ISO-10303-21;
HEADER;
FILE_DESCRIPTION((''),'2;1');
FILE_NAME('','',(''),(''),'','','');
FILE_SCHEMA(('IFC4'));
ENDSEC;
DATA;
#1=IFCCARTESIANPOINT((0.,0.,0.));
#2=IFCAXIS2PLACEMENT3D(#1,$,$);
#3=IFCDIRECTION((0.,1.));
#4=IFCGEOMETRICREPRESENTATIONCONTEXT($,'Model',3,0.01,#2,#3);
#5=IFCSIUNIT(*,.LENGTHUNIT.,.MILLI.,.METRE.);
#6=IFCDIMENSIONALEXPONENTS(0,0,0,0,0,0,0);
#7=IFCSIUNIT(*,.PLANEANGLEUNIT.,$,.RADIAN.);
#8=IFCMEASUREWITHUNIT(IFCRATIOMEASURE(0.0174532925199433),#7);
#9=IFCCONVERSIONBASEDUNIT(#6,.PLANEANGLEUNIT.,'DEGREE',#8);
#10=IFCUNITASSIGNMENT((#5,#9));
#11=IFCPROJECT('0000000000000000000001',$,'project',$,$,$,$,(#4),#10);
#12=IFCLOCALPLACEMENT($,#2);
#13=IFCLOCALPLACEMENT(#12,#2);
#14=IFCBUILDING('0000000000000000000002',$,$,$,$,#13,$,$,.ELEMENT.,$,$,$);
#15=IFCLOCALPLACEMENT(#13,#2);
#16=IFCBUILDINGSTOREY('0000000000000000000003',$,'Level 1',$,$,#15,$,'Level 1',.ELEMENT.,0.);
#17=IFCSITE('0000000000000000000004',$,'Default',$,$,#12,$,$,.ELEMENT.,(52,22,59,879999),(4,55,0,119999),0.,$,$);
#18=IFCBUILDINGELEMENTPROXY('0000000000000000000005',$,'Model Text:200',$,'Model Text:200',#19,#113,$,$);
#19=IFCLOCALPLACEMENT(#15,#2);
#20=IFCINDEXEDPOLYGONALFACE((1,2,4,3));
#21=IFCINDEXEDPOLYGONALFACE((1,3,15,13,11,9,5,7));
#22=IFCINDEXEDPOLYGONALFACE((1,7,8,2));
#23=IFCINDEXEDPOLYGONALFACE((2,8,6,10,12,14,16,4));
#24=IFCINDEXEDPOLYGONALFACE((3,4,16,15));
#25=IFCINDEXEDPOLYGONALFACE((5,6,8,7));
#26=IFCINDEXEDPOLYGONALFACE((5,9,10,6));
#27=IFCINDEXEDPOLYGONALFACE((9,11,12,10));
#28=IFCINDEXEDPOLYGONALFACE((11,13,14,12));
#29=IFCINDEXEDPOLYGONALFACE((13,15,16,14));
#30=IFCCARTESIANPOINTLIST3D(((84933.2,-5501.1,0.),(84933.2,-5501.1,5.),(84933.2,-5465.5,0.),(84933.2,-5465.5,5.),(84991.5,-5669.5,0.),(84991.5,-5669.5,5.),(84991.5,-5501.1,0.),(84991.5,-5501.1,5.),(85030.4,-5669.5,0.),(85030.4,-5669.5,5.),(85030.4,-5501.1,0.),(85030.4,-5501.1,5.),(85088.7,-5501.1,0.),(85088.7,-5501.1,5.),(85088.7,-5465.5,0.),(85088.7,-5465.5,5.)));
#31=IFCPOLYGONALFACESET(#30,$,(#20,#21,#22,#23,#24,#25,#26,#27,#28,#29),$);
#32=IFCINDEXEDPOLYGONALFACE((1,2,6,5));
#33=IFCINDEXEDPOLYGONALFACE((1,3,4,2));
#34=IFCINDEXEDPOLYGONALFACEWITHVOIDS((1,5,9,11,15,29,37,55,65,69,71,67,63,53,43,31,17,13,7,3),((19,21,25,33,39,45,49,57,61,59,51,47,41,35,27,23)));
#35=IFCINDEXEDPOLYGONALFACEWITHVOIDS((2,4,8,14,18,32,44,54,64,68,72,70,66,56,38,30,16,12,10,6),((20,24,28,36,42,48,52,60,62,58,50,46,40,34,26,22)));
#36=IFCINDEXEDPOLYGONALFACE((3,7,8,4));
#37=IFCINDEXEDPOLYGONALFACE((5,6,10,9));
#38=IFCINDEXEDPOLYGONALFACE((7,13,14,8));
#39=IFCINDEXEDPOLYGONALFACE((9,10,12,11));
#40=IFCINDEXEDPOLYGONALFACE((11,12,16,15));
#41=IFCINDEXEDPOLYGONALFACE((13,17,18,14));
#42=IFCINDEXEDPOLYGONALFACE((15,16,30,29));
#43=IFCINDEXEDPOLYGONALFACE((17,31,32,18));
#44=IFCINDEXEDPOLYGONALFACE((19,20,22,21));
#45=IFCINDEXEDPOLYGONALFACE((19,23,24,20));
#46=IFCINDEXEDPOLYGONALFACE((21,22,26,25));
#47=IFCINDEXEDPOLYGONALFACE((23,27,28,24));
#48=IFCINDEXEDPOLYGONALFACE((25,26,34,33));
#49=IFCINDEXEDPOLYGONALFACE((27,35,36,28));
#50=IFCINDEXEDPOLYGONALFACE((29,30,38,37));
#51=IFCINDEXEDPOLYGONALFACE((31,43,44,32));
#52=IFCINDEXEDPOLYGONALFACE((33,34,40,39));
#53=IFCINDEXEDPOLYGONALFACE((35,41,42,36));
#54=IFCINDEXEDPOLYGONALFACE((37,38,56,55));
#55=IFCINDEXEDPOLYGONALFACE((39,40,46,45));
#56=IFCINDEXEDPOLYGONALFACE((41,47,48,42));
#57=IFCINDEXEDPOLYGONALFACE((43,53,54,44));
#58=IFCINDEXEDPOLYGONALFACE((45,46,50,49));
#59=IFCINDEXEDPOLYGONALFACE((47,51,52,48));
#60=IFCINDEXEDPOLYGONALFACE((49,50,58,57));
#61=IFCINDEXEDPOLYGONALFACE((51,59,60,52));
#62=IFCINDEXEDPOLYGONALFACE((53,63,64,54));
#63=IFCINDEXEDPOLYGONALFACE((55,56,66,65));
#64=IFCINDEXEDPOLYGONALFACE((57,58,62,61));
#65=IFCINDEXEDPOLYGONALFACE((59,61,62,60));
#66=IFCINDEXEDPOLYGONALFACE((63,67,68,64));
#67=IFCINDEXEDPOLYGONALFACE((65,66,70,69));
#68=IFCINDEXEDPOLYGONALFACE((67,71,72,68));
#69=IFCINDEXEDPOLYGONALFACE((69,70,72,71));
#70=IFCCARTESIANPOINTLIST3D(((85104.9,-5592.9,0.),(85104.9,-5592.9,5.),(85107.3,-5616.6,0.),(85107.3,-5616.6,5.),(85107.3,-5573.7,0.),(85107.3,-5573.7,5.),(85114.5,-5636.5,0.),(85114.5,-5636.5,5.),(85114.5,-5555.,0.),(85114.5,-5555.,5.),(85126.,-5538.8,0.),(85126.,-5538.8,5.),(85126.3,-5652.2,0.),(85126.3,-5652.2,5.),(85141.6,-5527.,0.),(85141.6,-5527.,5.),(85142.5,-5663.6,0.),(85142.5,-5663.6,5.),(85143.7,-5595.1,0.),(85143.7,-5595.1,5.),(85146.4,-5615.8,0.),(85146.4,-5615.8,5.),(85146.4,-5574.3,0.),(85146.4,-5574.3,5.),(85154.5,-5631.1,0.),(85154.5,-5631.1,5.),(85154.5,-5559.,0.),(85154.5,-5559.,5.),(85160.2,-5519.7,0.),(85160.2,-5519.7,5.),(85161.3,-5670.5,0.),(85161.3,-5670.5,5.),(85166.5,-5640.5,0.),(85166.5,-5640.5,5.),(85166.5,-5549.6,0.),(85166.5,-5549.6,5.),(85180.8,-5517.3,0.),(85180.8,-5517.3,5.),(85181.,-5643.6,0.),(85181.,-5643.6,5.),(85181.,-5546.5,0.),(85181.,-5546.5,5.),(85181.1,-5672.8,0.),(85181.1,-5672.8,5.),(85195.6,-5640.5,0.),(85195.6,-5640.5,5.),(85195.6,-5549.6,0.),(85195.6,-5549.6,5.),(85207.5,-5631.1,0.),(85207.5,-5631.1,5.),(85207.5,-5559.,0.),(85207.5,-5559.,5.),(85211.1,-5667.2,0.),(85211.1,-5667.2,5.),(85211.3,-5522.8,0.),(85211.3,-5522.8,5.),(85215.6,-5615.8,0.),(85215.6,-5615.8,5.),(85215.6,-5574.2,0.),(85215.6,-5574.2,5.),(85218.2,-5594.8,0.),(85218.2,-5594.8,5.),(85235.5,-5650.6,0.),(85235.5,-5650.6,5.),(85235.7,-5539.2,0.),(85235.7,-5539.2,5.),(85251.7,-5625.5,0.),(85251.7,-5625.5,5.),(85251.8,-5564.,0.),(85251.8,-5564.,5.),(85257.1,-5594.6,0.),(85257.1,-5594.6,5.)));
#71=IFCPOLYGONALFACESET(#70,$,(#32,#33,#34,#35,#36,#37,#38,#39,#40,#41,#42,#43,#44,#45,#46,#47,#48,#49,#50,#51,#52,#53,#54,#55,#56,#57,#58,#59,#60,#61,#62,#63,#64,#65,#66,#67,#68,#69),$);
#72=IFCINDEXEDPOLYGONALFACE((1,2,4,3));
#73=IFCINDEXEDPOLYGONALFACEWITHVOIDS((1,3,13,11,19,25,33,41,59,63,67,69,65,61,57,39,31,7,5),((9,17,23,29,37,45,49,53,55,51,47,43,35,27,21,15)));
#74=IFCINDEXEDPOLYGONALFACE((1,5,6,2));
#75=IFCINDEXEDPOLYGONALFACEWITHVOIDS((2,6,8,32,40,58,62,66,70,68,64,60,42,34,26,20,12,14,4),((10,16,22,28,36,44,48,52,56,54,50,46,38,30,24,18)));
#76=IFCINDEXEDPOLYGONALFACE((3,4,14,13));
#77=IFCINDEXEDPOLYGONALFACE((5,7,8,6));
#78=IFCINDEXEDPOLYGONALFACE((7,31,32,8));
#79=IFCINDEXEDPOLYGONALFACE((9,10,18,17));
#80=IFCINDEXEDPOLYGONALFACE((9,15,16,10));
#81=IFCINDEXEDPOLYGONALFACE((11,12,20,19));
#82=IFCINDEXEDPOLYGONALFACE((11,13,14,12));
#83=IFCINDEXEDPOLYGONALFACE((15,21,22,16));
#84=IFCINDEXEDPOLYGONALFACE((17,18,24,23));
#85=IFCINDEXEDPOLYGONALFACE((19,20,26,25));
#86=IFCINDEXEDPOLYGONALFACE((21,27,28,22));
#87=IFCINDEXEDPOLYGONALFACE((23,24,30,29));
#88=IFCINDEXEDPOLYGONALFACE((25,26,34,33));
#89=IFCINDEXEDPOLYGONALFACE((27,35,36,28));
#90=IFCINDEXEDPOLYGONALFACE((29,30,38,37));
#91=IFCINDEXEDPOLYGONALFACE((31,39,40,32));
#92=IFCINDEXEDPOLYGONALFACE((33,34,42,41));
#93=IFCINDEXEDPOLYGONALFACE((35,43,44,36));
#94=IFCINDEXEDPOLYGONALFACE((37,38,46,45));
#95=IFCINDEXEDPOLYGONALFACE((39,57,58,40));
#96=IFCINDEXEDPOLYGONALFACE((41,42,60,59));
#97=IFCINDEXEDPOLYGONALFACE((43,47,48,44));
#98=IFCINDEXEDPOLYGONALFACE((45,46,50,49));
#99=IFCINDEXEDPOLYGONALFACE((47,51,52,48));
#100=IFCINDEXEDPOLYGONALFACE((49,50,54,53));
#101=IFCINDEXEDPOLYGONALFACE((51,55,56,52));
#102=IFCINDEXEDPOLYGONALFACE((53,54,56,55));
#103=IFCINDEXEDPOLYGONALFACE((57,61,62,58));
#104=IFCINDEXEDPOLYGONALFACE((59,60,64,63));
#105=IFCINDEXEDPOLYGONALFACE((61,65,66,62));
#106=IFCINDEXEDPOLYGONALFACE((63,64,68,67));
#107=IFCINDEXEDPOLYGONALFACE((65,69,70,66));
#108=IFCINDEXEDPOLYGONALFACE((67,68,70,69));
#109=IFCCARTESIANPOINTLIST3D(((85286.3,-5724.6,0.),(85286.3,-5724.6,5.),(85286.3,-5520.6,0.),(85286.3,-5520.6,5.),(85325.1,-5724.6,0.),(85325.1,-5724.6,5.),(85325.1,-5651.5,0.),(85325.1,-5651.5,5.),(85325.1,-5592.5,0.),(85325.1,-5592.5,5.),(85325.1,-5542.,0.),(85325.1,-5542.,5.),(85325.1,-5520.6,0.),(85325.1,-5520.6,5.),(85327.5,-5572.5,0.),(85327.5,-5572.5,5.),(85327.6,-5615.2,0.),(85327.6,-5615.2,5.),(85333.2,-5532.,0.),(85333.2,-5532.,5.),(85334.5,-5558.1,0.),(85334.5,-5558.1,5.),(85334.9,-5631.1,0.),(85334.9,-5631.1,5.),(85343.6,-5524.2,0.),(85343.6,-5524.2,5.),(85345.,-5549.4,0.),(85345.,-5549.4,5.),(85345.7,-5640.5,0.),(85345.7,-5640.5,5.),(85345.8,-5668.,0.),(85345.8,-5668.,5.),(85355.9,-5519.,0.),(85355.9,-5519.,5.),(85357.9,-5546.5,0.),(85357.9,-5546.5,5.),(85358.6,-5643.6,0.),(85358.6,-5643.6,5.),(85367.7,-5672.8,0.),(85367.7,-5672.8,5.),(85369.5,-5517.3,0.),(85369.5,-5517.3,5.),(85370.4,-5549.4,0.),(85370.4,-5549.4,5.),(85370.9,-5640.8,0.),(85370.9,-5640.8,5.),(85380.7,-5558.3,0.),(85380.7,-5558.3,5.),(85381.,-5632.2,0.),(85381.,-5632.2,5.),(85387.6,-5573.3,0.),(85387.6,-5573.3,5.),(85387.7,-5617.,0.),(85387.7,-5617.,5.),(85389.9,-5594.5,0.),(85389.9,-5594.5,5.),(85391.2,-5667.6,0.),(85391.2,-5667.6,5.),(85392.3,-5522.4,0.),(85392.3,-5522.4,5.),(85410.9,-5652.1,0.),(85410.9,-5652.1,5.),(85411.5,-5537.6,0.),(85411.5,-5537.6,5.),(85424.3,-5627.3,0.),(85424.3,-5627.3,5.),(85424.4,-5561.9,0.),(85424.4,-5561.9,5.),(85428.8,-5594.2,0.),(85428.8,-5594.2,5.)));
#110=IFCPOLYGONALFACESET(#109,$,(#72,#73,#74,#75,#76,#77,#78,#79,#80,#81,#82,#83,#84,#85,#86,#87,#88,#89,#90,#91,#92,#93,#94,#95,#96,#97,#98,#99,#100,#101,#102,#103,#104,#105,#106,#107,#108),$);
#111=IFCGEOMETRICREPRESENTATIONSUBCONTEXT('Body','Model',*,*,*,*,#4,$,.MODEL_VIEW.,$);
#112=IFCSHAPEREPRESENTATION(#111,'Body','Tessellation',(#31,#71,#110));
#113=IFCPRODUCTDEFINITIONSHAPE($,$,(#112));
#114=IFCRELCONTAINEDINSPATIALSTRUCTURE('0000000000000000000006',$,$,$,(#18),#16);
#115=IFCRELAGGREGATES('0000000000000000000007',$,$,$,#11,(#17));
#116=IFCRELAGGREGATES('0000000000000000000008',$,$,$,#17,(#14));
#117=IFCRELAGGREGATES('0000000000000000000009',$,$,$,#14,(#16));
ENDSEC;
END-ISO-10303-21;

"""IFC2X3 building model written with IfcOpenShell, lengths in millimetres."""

from ifc_helpers import new_model, entity, si_unit, converted_unit, direction, frame, origin, place, context, subcontext, project, spatial, polyline, outline, extrude, element, save


model = new_model("IFC2X3")

# Units and contexts
model_context = context("Model", 3, precision=0.01, world=origin(), true_north=direction((0.0, 1.0)))
body_context = subcontext(model_context, "Body", "Model", "MODEL_VIEW")
ifc_project = project(units=[si_unit("LENGTHUNIT", "METRE", prefix="MILLI"), converted_unit("PLANEANGLEUNIT", "DEGREE", entity("IfcRatioMeasure", 0.0174532925199433), si_unit("PLANEANGLEUNIT", "RADIAN"), dimensions=[0, 0, 0, 0, 0, 0, 0])], contexts=[model_context])

# Site, building, storey
site_placement = place(None, origin())
site = spatial("IfcSite", under=ifc_project, at=site_placement, Name="Default", CompositionType="ELEMENT", RefLatitude=(52, 22, 59, 879999), RefLongitude=(4, 55, 0, 119999), RefElevation=0.0)
building_placement = place(site_placement, origin())
building = spatial("IfcBuilding", under=site, at=building_placement, CompositionType="ELEMENT")
storey_placement = place(building_placement, origin())
storey = spatial("IfcBuildingStorey", under=building, at=storey_placement, Name="Level 1", LongName="Level 1", CompositionType="ELEMENT", Elevation=0.0)

# Building element proxy
proxy_1_placement = place(building_placement, origin())
element("IfcBuildingElementProxy", 1, at=proxy_1_placement, inside=storey, Name="Model Text:200", ObjectType="Model Text:200", context=body_context, shape_type="SweptSolid", body=[
    extrude(outline(polyline([(-19.4, -135.2), (19.4, -135.2), (19.4, 33.2), (77.7, 33.2), (77.7, 68.8), (-77.7, 68.8), (-77.7, 33.2), (-19.4, 33.2), (-19.4, -135.2)])), frame((85010.9, -5534.3, 0.0)), (0.0, 0.0, 1.0), 5.0),
    extrude(outline(polyline([(-8.8, -65.7), (15.1, -65.7), (35.5, -60.5), (52.3, -50.4), (65.3, -35.4), (74.1, -17.3), (78.4, 2.1), (75.9, 32.5), (61.8, 58.5), (38.4, 77.1), (8.3, 85.6), (-22.7, 83.3), (-49.0, 69.9), (-67.8, 47.3), (-76.3, 17.5), (-76.0, -3.3), (-70.7, -22.5), (-60.5, -39.2), (-45.5, -52.3), (-27.7, -61.4), (-8.8, -65.7)]), holes=[polyline([(-2.7, -27.2), (-23.1, -22.5), (-37.5, -12.9), (-45.7, 0.0), (-47.3, 14.8), (-42.7, 28.9), (-32.2, 39.9), (-16.3, 46.3), (4.5, 46.9), (25.1, 42.1), (39.6, 32.6), (47.7, 19.7), (49.4, 5.0), (44.8, -9.2), (34.2, -20.2), (18.2, -26.7), (-2.7, -27.2)])]), frame((85171.1, -5595.0, 0.0), z_axis=(0.0, 0.0, 1.0), x_axis=(0.100608, -0.994926, 0.0)), (0.0, 0.0, 1.0), 5.0),
    extrude(outline(polyline([(-73.1, -75.4), (130.9, -75.4), (130.9, -36.6), (57.8, -36.6), (74.3, -15.9), (79.1, 6.0), (73.9, 29.5), (58.4, 49.2), (33.6, 62.6), (0.5, 67.1), (-31.8, 62.8), (-56.1, 49.8), (-71.3, 30.7), (-76.4, 7.8), (-74.7, -5.8), (-69.6, -18.1), (-61.7, -28.5), (-51.7, -36.6), (-73.1, -36.6), (-73.1, -75.4)]), holes=[polyline([(-1.2, -36.6), (-21.2, -34.2), (-35.6, -27.2), (-44.3, -16.7), (-47.2, -3.8), (-44.3, 8.7), (-35.4, 19.0), (-20.4, 25.9), (0.8, 28.2), (23.3, 26.0), (38.5, 19.3), (47.1, 9.2), (49.9, -3.1), (46.8, -16.0), (37.4, -26.8), (21.5, -34.1), (-1.2, -36.6)])]), frame((85361.7, -5593.7, 0.0), z_axis=(0.0, 0.0, 1.0), x_axis=(0.0, -1.0, 0.0)), (0.0, 0.0, 1.0), 5.0),
])

save(model, "model.ifc")
